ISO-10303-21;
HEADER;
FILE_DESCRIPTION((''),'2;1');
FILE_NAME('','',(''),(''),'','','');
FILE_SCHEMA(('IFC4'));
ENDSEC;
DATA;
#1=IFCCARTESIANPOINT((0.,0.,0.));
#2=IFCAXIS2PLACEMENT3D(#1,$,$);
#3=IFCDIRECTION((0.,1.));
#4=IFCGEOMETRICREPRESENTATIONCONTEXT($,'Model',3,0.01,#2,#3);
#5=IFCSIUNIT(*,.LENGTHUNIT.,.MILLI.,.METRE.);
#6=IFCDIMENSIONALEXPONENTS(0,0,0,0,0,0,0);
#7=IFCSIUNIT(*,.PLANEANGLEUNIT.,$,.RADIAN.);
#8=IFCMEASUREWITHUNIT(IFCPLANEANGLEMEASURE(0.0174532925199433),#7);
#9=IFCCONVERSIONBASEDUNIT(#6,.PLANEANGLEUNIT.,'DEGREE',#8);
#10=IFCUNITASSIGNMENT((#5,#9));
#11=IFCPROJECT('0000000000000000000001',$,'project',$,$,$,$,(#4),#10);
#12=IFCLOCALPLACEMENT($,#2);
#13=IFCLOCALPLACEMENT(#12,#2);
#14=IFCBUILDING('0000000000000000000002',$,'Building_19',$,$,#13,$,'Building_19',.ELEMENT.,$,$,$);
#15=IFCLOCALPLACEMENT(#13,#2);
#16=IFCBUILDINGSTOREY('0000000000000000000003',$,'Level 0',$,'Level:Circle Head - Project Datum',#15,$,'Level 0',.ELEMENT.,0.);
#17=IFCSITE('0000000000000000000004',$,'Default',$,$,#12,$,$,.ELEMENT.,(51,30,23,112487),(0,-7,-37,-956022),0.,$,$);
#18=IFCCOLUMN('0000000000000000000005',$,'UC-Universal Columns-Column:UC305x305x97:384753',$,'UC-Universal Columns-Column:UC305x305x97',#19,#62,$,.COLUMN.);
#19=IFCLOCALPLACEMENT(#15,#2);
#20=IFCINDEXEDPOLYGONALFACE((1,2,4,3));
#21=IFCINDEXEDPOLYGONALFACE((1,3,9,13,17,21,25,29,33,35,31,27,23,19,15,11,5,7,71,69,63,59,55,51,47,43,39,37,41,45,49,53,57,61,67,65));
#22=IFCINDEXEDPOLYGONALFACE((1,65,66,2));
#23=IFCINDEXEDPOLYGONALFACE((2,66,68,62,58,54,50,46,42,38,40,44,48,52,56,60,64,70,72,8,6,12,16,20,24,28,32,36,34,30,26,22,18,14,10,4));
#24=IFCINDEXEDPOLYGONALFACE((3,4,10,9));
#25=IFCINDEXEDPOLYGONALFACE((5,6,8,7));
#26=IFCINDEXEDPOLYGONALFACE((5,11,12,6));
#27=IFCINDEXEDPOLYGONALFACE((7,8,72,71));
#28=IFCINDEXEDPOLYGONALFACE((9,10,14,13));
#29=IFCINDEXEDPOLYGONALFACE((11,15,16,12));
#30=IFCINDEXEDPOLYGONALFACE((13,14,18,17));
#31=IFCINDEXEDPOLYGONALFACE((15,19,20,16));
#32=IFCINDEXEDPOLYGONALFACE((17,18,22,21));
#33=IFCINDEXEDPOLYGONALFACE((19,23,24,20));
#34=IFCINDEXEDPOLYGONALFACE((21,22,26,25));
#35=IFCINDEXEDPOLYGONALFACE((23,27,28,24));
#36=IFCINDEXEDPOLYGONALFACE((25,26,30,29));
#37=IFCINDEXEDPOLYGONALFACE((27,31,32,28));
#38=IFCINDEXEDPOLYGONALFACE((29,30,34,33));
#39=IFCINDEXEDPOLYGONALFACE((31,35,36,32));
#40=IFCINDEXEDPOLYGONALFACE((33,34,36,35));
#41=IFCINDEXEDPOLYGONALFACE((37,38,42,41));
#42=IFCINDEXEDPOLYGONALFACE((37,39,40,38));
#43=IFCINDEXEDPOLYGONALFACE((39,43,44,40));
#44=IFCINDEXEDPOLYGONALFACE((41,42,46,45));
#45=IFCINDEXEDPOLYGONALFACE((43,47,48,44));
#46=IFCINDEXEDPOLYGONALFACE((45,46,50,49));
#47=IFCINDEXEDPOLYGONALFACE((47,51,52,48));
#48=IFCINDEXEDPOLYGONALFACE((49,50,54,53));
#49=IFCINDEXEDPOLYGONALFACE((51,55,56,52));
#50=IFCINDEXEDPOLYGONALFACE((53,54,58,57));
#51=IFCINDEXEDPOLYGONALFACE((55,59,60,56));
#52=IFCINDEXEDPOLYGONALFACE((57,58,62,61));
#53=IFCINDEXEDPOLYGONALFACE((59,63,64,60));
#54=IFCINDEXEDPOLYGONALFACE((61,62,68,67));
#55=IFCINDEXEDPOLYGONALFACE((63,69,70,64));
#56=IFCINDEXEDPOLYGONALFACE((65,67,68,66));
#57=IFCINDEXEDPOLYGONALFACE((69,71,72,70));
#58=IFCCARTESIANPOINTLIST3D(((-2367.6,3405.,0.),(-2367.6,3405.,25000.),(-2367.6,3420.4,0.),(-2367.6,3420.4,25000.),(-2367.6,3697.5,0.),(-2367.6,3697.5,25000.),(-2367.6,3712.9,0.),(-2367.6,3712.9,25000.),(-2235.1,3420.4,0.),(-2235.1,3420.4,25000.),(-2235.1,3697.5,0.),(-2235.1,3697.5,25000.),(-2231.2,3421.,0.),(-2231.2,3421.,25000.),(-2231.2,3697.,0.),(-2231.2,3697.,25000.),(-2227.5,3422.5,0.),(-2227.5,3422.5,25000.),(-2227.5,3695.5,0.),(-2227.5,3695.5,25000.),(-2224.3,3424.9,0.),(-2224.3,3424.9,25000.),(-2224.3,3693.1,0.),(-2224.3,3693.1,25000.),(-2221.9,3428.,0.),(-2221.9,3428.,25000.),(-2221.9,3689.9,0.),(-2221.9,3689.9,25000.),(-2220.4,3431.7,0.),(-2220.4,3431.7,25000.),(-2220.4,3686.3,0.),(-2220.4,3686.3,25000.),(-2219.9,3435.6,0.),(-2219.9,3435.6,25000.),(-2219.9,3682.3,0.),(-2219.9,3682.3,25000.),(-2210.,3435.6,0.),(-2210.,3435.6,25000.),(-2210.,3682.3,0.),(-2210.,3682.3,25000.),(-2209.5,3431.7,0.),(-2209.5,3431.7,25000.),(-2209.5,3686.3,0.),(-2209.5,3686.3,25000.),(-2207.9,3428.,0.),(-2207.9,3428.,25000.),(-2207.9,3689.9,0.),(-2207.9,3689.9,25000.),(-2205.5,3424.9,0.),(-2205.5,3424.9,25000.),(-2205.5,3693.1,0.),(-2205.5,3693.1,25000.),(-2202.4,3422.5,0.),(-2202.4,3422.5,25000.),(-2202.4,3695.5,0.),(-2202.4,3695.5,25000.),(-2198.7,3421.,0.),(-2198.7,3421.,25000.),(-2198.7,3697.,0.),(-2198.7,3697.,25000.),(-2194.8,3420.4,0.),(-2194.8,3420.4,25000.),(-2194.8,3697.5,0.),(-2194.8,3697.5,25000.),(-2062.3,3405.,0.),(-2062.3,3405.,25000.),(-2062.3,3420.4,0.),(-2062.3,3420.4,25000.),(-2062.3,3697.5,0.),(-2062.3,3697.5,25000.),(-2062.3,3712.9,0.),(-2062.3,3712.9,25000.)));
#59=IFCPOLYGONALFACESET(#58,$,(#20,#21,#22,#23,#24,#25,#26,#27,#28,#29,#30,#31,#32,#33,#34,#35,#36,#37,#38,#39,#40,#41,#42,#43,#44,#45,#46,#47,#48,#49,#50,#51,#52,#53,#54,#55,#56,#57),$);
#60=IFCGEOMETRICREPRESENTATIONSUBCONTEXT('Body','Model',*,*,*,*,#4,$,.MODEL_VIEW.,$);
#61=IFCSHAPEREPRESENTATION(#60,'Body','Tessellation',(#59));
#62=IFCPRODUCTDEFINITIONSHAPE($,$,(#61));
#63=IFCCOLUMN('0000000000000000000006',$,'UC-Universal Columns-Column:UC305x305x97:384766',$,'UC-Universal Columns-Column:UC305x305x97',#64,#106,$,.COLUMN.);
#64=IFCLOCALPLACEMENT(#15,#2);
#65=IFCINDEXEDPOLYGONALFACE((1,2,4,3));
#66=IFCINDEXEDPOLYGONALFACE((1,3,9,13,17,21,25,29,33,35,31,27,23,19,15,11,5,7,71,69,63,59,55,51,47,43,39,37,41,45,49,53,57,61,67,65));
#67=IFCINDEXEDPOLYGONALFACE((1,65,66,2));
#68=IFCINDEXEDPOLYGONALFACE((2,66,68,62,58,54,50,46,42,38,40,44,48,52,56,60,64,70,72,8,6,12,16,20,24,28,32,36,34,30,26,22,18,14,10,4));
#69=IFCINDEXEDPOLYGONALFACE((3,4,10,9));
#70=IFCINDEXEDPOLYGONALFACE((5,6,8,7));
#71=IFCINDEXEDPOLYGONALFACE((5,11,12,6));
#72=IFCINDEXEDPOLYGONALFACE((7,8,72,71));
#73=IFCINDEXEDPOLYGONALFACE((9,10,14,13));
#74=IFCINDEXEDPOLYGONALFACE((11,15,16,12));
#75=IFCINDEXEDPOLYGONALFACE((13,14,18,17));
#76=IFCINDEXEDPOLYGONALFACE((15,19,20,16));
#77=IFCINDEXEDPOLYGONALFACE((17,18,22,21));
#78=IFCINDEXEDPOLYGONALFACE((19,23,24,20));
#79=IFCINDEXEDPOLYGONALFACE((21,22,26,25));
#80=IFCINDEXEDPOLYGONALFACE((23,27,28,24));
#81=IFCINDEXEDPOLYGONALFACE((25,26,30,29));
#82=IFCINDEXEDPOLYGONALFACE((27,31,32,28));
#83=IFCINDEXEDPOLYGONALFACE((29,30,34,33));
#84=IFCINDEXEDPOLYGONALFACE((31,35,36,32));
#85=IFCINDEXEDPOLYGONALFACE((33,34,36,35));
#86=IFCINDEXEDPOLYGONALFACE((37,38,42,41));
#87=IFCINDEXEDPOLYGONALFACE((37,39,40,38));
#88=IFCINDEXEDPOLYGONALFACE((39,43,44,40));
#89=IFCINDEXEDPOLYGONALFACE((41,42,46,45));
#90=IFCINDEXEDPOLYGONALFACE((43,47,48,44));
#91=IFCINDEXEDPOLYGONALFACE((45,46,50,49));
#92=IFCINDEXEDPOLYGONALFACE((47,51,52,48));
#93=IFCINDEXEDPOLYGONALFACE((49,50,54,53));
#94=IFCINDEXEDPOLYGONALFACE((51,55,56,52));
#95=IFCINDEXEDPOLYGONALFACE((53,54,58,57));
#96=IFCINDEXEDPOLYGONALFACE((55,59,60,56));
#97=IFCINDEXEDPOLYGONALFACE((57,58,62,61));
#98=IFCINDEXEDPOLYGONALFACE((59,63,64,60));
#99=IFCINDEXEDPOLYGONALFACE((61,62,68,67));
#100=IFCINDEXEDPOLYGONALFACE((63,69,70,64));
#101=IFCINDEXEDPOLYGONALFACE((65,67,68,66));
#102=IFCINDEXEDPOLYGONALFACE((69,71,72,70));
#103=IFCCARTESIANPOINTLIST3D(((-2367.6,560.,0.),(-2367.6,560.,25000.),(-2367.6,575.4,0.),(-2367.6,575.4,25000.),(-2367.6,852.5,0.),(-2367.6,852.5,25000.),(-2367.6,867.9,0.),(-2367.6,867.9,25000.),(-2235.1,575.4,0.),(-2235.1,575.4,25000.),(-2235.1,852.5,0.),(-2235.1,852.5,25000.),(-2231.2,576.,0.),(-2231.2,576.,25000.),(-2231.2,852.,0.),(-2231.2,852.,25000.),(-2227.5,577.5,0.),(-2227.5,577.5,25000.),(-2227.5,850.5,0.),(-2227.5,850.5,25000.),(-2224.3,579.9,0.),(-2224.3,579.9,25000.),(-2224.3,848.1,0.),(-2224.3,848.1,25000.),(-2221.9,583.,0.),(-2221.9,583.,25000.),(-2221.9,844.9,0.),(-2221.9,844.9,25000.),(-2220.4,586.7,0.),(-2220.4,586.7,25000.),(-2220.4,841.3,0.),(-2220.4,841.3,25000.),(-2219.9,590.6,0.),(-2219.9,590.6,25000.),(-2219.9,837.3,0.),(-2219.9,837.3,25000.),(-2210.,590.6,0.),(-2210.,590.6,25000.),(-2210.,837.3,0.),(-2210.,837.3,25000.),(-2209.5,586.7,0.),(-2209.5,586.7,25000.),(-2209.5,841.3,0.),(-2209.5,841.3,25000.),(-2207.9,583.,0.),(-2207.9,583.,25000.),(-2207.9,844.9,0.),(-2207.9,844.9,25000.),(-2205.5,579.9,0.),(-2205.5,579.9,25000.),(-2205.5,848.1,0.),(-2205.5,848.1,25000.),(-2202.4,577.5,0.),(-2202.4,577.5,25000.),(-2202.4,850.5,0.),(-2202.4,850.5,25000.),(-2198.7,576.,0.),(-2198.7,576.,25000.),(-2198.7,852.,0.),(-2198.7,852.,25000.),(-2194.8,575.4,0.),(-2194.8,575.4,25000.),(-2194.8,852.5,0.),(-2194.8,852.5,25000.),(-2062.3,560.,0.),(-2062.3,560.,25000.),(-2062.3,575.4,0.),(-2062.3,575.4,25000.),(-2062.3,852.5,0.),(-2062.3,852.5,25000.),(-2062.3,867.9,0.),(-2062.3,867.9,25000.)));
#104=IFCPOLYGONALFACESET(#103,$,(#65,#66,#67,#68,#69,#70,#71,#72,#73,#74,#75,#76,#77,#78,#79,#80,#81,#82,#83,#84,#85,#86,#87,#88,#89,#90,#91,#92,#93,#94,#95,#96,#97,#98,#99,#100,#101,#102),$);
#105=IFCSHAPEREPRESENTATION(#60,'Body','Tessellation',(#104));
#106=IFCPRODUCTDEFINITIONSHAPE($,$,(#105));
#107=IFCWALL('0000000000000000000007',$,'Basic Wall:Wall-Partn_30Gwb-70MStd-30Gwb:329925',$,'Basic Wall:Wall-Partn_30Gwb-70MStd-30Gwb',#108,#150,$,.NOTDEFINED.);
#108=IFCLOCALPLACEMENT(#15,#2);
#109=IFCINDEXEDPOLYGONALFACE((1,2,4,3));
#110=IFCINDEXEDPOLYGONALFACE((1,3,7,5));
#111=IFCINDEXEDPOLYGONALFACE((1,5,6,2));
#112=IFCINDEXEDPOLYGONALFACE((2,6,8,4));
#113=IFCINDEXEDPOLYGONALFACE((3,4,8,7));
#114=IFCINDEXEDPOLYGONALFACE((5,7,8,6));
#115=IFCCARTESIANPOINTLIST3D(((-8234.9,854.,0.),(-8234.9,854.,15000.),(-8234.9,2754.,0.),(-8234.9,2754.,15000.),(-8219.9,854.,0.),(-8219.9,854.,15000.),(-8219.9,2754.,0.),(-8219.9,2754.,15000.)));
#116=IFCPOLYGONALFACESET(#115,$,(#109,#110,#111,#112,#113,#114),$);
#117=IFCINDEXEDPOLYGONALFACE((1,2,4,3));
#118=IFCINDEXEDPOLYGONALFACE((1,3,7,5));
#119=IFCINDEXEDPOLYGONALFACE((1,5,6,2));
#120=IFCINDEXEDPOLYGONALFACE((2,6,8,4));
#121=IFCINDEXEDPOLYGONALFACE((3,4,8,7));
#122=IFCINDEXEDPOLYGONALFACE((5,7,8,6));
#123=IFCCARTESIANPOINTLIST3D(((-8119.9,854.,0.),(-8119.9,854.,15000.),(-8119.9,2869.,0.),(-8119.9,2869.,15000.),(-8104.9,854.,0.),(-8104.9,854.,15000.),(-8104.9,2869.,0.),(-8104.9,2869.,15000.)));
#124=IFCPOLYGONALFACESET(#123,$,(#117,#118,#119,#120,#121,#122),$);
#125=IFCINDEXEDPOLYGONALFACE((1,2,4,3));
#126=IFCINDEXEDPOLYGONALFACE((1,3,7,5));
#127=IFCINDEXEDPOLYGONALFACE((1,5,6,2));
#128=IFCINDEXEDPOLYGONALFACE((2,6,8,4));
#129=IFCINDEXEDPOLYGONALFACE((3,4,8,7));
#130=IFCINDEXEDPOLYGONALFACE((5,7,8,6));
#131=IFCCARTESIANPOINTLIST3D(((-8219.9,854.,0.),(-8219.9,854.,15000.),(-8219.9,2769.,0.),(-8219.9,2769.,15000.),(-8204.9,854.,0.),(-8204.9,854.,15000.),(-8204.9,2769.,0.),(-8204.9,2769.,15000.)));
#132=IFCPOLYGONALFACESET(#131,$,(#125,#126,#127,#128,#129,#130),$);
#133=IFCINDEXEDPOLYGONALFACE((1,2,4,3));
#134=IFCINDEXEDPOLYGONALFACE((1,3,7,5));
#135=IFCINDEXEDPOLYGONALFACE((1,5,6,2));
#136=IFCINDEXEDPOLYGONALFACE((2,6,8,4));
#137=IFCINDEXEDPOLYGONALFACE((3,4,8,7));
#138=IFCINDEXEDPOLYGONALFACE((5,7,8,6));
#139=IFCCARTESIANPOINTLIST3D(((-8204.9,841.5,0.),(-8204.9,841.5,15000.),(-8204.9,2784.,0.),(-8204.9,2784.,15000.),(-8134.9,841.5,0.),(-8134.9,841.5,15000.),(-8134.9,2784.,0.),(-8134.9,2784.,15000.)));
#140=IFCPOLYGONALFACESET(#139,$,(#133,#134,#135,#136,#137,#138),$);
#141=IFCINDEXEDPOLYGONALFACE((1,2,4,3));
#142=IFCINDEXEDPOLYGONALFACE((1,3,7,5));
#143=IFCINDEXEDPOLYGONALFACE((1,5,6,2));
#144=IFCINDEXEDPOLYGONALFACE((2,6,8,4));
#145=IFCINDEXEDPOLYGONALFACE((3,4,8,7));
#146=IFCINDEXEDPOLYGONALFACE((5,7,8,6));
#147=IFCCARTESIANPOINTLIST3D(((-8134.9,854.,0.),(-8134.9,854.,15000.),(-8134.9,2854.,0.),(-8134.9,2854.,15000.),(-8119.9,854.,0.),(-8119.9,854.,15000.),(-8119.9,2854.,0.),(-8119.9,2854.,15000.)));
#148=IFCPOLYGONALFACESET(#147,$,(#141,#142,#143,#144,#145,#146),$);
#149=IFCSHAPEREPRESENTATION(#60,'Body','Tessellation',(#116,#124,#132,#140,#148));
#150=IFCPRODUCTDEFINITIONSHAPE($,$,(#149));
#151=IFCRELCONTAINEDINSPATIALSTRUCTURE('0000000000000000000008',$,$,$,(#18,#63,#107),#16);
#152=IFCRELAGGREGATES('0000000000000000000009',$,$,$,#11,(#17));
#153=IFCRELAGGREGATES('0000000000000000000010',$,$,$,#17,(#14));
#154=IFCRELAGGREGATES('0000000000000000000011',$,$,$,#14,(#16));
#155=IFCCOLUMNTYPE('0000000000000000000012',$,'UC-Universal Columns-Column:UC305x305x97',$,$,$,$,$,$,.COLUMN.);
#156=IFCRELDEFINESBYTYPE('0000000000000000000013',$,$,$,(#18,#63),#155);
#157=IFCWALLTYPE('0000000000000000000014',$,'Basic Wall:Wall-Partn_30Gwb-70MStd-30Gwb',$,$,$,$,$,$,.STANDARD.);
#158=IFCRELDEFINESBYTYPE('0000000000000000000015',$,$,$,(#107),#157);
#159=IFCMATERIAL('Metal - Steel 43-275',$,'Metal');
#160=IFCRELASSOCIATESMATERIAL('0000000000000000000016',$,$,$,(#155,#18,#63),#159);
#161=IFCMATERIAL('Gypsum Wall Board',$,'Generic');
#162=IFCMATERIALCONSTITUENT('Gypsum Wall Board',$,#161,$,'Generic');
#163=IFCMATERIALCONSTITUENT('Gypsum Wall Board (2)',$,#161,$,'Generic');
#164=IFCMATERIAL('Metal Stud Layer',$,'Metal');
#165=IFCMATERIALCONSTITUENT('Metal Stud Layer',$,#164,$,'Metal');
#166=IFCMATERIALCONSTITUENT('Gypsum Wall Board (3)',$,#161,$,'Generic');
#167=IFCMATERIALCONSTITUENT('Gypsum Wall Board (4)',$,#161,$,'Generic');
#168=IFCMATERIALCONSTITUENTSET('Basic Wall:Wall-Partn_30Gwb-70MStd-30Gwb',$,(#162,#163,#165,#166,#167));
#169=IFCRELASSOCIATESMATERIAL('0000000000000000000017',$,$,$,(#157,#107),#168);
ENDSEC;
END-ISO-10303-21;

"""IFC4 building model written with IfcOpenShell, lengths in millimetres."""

from ifc_helpers import new_model, entity, si_unit, converted_unit, direction, frame, origin, place, context, subcontext, project, spatial, line, arc, indexed_curve, outline, extrude, source, transform, mapped, material, constituent, constituent_set, type_object, type_shapes, element, save


model = new_model("IFC4")

# Units and contexts
model_context = context("Model", 3, precision=0.01, world=origin(), true_north=direction((0.0, 1.0)))
body_context = subcontext(model_context, "Body", "Model", "MODEL_VIEW")
ifc_project = project(units=[si_unit("LENGTHUNIT", "METRE", prefix="MILLI"), converted_unit("PLANEANGLEUNIT", "DEGREE", entity("IfcPlaneAngleMeasure", 0.0174532925199433), si_unit("PLANEANGLEUNIT", "RADIAN"), dimensions=[0, 0, 0, 0, 0, 0, 0])], contexts=[model_context])

# Site, building, storey
site_placement = place(None, origin())
site = spatial("IfcSite", under=ifc_project, at=site_placement, Name="Default", CompositionType="ELEMENT", RefLatitude=(51, 30, 23, 112487), RefLongitude=(0, -7, -37, -956022), RefElevation=0.0)
building_placement = place(site_placement, origin())
building = spatial("IfcBuilding", under=site, at=building_placement, Name="Building_19", LongName="Building_19", CompositionType="ELEMENT")
storey_placement = place(building_placement, origin())
storey = spatial("IfcBuildingStorey", under=building, at=storey_placement, Name="Level 0", ObjectType="Level:Circle Head - Project Datum", LongName="Level 0", CompositionType="ELEMENT", Elevation=0.0)

# Columns
ifc_material_1 = material(Name="Metal - Steel 43-275", Category="Metal")
column_type = type_object("IfcColumnType", Name="UC-Universal Columns-Column:UC305x305x97", PredefinedType="COLUMN", material=ifc_material_1)
shared_shape_1 = source(origin(), body_context, "Body", "SweptSolid", [
    extrude(outline(indexed_curve([(-152.7, -153.9), (152.7, -153.9), (152.7, -138.6), (20.2, -138.6), (9.4, -134.1), (4.9, -123.3), (4.9, 123.3), (9.4, 134.1), (20.1, 138.6), (152.7, 138.6), (152.7, 153.9), (-152.7, 153.9), (-152.7, 138.6), (-20.2, 138.6), (-9.4, 134.1), (-5.0, 123.3), (-5.0, -123.3), (-9.4, -134.1), (-20.2, -138.6), (-152.7, -138.6)], segments=[line(1, 2, 3, 4), arc(4, 5, 6), line(6, 7), arc(7, 8, 9), line(9, 10, 11, 12, 13, 14), arc(14, 15, 16), line(16, 17), arc(17, 18, 19), line(19, 20, 1)], self_intersect=False)), frame((0.0, 0.0, 0.0), z_axis=(0.0, 0.0, 1.0), x_axis=(-1.0, 0.0, 0.0)), (0.0, 0.0, 1.0), 25000.0),
])
type_shapes(column_type, [shared_shape_1])
for number, where, name in (
    (1, (-2214.9, 3559.0, 0.0), "UC-Universal Columns-Column:UC305x305x97:384753"),
    (2, (-2214.9, 714.0, 0.0), "UC-Universal Columns-Column:UC305x305x97:384766"),
):
    element("IfcColumn", number, at=place(storey_placement, frame(where)), inside=storey, type_object=column_type, material=ifc_material_1, Name=name, ObjectType="UC-Universal Columns-Column:UC305x305x97", PredefinedType="COLUMN", context=body_context, shape_type="MappedRepresentation", body=[
        mapped(shared_shape_1, transform((0.0, 0.0, 0.0), scale=1.0)),
    ])

# Wall
ifc_material_2 = material(Name="Gypsum Wall Board", Category="Generic")
ifc_constituent_1 = constituent(ifc_material_2, Name="Gypsum Wall Board", Category="Generic")
ifc_constituent_2 = constituent(ifc_material_2, Name="Gypsum Wall Board (2)", Category="Generic")
ifc_material_3 = material(Name="Metal Stud Layer", Category="Metal")
ifc_constituent_3 = constituent(ifc_material_3, Name="Metal Stud Layer", Category="Metal")
ifc_constituent_4 = constituent(ifc_material_2, Name="Gypsum Wall Board (3)", Category="Generic")
ifc_constituent_5 = constituent(ifc_material_2, Name="Gypsum Wall Board (4)", Category="Generic")
ifc_constituent_set_1 = constituent_set(constituents=[ifc_constituent_1, ifc_constituent_2, ifc_constituent_3, ifc_constituent_4, ifc_constituent_5], Name="Basic Wall:Wall-Partn_30Gwb-70MStd-30Gwb")
wall_type_1 = type_object("IfcWallType", Name="Basic Wall:Wall-Partn_30Gwb-70MStd-30Gwb", PredefinedType="STANDARD", material=ifc_constituent_set_1)
wall_1_placement = place(storey_placement, frame((-8169.9, 2754.0, 0.0), z_axis=(0.0, 0.0, 1.0), x_axis=(0.0, -1.0, 0.0)))
element("IfcWall", 3, at=wall_1_placement, inside=storey, type_object=wall_type_1, material=ifc_constituent_set_1, Name="Basic Wall:Wall-Partn_30Gwb-70MStd-30Gwb:329925", ObjectType="Basic Wall:Wall-Partn_30Gwb-70MStd-30Gwb", PredefinedType="NOTDEFINED", context=body_context, shape_type="SweptSolid", body=[
    extrude(outline(indexed_curve([(-7.5, -950.0), (7.5, -950.0), (7.5, 950.0), (-7.5, 950.0), (-7.5, -950.0)], self_intersect=False)), frame((950.0, -57.5, 0.0), z_axis=(0.0, 0.0, 1.0), x_axis=(0.0, 1.0, 0.0)), (0.0, 0.0, 1.0), 15000.0),
    extrude(outline(indexed_curve([(-7.5, -1007.5), (7.5, -1007.5), (7.5, 1007.5), (-7.5, 1007.5), (-7.5, -1007.5)], self_intersect=False)), frame((892.5, 57.5, 0.0), z_axis=(0.0, 0.0, 1.0), x_axis=(0.0, -1.0, 0.0)), (0.0, 0.0, 1.0), 15000.0),
    extrude(outline(indexed_curve([(-957.5, -7.5), (957.5, -7.5), (957.5, 7.5), (-957.5, 7.5), (-957.5, -7.5)], self_intersect=False)), frame((942.5, -42.5, 0.0)), (0.0, 0.0, 1.0), 15000.0),
    extrude(outline(indexed_curve([(-971.2, -35.0), (971.2, -35.0), (971.2, 35.0), (-971.2, 35.0), (-971.2, -35.0)], self_intersect=False)), frame((941.2, 0.0, 0.0)), (0.0, 0.0, 1.0), 15000.0),
    extrude(outline(indexed_curve([(-1000.0, -7.5), (1000.0, -7.5), (1000.0, 7.5), (-1000.0, 7.5), (-1000.0, -7.5)], self_intersect=False)), frame((900.0, 42.5, 0.0)), (0.0, 0.0, 1.0), 15000.0),
])

save(model, "model.ifc")
